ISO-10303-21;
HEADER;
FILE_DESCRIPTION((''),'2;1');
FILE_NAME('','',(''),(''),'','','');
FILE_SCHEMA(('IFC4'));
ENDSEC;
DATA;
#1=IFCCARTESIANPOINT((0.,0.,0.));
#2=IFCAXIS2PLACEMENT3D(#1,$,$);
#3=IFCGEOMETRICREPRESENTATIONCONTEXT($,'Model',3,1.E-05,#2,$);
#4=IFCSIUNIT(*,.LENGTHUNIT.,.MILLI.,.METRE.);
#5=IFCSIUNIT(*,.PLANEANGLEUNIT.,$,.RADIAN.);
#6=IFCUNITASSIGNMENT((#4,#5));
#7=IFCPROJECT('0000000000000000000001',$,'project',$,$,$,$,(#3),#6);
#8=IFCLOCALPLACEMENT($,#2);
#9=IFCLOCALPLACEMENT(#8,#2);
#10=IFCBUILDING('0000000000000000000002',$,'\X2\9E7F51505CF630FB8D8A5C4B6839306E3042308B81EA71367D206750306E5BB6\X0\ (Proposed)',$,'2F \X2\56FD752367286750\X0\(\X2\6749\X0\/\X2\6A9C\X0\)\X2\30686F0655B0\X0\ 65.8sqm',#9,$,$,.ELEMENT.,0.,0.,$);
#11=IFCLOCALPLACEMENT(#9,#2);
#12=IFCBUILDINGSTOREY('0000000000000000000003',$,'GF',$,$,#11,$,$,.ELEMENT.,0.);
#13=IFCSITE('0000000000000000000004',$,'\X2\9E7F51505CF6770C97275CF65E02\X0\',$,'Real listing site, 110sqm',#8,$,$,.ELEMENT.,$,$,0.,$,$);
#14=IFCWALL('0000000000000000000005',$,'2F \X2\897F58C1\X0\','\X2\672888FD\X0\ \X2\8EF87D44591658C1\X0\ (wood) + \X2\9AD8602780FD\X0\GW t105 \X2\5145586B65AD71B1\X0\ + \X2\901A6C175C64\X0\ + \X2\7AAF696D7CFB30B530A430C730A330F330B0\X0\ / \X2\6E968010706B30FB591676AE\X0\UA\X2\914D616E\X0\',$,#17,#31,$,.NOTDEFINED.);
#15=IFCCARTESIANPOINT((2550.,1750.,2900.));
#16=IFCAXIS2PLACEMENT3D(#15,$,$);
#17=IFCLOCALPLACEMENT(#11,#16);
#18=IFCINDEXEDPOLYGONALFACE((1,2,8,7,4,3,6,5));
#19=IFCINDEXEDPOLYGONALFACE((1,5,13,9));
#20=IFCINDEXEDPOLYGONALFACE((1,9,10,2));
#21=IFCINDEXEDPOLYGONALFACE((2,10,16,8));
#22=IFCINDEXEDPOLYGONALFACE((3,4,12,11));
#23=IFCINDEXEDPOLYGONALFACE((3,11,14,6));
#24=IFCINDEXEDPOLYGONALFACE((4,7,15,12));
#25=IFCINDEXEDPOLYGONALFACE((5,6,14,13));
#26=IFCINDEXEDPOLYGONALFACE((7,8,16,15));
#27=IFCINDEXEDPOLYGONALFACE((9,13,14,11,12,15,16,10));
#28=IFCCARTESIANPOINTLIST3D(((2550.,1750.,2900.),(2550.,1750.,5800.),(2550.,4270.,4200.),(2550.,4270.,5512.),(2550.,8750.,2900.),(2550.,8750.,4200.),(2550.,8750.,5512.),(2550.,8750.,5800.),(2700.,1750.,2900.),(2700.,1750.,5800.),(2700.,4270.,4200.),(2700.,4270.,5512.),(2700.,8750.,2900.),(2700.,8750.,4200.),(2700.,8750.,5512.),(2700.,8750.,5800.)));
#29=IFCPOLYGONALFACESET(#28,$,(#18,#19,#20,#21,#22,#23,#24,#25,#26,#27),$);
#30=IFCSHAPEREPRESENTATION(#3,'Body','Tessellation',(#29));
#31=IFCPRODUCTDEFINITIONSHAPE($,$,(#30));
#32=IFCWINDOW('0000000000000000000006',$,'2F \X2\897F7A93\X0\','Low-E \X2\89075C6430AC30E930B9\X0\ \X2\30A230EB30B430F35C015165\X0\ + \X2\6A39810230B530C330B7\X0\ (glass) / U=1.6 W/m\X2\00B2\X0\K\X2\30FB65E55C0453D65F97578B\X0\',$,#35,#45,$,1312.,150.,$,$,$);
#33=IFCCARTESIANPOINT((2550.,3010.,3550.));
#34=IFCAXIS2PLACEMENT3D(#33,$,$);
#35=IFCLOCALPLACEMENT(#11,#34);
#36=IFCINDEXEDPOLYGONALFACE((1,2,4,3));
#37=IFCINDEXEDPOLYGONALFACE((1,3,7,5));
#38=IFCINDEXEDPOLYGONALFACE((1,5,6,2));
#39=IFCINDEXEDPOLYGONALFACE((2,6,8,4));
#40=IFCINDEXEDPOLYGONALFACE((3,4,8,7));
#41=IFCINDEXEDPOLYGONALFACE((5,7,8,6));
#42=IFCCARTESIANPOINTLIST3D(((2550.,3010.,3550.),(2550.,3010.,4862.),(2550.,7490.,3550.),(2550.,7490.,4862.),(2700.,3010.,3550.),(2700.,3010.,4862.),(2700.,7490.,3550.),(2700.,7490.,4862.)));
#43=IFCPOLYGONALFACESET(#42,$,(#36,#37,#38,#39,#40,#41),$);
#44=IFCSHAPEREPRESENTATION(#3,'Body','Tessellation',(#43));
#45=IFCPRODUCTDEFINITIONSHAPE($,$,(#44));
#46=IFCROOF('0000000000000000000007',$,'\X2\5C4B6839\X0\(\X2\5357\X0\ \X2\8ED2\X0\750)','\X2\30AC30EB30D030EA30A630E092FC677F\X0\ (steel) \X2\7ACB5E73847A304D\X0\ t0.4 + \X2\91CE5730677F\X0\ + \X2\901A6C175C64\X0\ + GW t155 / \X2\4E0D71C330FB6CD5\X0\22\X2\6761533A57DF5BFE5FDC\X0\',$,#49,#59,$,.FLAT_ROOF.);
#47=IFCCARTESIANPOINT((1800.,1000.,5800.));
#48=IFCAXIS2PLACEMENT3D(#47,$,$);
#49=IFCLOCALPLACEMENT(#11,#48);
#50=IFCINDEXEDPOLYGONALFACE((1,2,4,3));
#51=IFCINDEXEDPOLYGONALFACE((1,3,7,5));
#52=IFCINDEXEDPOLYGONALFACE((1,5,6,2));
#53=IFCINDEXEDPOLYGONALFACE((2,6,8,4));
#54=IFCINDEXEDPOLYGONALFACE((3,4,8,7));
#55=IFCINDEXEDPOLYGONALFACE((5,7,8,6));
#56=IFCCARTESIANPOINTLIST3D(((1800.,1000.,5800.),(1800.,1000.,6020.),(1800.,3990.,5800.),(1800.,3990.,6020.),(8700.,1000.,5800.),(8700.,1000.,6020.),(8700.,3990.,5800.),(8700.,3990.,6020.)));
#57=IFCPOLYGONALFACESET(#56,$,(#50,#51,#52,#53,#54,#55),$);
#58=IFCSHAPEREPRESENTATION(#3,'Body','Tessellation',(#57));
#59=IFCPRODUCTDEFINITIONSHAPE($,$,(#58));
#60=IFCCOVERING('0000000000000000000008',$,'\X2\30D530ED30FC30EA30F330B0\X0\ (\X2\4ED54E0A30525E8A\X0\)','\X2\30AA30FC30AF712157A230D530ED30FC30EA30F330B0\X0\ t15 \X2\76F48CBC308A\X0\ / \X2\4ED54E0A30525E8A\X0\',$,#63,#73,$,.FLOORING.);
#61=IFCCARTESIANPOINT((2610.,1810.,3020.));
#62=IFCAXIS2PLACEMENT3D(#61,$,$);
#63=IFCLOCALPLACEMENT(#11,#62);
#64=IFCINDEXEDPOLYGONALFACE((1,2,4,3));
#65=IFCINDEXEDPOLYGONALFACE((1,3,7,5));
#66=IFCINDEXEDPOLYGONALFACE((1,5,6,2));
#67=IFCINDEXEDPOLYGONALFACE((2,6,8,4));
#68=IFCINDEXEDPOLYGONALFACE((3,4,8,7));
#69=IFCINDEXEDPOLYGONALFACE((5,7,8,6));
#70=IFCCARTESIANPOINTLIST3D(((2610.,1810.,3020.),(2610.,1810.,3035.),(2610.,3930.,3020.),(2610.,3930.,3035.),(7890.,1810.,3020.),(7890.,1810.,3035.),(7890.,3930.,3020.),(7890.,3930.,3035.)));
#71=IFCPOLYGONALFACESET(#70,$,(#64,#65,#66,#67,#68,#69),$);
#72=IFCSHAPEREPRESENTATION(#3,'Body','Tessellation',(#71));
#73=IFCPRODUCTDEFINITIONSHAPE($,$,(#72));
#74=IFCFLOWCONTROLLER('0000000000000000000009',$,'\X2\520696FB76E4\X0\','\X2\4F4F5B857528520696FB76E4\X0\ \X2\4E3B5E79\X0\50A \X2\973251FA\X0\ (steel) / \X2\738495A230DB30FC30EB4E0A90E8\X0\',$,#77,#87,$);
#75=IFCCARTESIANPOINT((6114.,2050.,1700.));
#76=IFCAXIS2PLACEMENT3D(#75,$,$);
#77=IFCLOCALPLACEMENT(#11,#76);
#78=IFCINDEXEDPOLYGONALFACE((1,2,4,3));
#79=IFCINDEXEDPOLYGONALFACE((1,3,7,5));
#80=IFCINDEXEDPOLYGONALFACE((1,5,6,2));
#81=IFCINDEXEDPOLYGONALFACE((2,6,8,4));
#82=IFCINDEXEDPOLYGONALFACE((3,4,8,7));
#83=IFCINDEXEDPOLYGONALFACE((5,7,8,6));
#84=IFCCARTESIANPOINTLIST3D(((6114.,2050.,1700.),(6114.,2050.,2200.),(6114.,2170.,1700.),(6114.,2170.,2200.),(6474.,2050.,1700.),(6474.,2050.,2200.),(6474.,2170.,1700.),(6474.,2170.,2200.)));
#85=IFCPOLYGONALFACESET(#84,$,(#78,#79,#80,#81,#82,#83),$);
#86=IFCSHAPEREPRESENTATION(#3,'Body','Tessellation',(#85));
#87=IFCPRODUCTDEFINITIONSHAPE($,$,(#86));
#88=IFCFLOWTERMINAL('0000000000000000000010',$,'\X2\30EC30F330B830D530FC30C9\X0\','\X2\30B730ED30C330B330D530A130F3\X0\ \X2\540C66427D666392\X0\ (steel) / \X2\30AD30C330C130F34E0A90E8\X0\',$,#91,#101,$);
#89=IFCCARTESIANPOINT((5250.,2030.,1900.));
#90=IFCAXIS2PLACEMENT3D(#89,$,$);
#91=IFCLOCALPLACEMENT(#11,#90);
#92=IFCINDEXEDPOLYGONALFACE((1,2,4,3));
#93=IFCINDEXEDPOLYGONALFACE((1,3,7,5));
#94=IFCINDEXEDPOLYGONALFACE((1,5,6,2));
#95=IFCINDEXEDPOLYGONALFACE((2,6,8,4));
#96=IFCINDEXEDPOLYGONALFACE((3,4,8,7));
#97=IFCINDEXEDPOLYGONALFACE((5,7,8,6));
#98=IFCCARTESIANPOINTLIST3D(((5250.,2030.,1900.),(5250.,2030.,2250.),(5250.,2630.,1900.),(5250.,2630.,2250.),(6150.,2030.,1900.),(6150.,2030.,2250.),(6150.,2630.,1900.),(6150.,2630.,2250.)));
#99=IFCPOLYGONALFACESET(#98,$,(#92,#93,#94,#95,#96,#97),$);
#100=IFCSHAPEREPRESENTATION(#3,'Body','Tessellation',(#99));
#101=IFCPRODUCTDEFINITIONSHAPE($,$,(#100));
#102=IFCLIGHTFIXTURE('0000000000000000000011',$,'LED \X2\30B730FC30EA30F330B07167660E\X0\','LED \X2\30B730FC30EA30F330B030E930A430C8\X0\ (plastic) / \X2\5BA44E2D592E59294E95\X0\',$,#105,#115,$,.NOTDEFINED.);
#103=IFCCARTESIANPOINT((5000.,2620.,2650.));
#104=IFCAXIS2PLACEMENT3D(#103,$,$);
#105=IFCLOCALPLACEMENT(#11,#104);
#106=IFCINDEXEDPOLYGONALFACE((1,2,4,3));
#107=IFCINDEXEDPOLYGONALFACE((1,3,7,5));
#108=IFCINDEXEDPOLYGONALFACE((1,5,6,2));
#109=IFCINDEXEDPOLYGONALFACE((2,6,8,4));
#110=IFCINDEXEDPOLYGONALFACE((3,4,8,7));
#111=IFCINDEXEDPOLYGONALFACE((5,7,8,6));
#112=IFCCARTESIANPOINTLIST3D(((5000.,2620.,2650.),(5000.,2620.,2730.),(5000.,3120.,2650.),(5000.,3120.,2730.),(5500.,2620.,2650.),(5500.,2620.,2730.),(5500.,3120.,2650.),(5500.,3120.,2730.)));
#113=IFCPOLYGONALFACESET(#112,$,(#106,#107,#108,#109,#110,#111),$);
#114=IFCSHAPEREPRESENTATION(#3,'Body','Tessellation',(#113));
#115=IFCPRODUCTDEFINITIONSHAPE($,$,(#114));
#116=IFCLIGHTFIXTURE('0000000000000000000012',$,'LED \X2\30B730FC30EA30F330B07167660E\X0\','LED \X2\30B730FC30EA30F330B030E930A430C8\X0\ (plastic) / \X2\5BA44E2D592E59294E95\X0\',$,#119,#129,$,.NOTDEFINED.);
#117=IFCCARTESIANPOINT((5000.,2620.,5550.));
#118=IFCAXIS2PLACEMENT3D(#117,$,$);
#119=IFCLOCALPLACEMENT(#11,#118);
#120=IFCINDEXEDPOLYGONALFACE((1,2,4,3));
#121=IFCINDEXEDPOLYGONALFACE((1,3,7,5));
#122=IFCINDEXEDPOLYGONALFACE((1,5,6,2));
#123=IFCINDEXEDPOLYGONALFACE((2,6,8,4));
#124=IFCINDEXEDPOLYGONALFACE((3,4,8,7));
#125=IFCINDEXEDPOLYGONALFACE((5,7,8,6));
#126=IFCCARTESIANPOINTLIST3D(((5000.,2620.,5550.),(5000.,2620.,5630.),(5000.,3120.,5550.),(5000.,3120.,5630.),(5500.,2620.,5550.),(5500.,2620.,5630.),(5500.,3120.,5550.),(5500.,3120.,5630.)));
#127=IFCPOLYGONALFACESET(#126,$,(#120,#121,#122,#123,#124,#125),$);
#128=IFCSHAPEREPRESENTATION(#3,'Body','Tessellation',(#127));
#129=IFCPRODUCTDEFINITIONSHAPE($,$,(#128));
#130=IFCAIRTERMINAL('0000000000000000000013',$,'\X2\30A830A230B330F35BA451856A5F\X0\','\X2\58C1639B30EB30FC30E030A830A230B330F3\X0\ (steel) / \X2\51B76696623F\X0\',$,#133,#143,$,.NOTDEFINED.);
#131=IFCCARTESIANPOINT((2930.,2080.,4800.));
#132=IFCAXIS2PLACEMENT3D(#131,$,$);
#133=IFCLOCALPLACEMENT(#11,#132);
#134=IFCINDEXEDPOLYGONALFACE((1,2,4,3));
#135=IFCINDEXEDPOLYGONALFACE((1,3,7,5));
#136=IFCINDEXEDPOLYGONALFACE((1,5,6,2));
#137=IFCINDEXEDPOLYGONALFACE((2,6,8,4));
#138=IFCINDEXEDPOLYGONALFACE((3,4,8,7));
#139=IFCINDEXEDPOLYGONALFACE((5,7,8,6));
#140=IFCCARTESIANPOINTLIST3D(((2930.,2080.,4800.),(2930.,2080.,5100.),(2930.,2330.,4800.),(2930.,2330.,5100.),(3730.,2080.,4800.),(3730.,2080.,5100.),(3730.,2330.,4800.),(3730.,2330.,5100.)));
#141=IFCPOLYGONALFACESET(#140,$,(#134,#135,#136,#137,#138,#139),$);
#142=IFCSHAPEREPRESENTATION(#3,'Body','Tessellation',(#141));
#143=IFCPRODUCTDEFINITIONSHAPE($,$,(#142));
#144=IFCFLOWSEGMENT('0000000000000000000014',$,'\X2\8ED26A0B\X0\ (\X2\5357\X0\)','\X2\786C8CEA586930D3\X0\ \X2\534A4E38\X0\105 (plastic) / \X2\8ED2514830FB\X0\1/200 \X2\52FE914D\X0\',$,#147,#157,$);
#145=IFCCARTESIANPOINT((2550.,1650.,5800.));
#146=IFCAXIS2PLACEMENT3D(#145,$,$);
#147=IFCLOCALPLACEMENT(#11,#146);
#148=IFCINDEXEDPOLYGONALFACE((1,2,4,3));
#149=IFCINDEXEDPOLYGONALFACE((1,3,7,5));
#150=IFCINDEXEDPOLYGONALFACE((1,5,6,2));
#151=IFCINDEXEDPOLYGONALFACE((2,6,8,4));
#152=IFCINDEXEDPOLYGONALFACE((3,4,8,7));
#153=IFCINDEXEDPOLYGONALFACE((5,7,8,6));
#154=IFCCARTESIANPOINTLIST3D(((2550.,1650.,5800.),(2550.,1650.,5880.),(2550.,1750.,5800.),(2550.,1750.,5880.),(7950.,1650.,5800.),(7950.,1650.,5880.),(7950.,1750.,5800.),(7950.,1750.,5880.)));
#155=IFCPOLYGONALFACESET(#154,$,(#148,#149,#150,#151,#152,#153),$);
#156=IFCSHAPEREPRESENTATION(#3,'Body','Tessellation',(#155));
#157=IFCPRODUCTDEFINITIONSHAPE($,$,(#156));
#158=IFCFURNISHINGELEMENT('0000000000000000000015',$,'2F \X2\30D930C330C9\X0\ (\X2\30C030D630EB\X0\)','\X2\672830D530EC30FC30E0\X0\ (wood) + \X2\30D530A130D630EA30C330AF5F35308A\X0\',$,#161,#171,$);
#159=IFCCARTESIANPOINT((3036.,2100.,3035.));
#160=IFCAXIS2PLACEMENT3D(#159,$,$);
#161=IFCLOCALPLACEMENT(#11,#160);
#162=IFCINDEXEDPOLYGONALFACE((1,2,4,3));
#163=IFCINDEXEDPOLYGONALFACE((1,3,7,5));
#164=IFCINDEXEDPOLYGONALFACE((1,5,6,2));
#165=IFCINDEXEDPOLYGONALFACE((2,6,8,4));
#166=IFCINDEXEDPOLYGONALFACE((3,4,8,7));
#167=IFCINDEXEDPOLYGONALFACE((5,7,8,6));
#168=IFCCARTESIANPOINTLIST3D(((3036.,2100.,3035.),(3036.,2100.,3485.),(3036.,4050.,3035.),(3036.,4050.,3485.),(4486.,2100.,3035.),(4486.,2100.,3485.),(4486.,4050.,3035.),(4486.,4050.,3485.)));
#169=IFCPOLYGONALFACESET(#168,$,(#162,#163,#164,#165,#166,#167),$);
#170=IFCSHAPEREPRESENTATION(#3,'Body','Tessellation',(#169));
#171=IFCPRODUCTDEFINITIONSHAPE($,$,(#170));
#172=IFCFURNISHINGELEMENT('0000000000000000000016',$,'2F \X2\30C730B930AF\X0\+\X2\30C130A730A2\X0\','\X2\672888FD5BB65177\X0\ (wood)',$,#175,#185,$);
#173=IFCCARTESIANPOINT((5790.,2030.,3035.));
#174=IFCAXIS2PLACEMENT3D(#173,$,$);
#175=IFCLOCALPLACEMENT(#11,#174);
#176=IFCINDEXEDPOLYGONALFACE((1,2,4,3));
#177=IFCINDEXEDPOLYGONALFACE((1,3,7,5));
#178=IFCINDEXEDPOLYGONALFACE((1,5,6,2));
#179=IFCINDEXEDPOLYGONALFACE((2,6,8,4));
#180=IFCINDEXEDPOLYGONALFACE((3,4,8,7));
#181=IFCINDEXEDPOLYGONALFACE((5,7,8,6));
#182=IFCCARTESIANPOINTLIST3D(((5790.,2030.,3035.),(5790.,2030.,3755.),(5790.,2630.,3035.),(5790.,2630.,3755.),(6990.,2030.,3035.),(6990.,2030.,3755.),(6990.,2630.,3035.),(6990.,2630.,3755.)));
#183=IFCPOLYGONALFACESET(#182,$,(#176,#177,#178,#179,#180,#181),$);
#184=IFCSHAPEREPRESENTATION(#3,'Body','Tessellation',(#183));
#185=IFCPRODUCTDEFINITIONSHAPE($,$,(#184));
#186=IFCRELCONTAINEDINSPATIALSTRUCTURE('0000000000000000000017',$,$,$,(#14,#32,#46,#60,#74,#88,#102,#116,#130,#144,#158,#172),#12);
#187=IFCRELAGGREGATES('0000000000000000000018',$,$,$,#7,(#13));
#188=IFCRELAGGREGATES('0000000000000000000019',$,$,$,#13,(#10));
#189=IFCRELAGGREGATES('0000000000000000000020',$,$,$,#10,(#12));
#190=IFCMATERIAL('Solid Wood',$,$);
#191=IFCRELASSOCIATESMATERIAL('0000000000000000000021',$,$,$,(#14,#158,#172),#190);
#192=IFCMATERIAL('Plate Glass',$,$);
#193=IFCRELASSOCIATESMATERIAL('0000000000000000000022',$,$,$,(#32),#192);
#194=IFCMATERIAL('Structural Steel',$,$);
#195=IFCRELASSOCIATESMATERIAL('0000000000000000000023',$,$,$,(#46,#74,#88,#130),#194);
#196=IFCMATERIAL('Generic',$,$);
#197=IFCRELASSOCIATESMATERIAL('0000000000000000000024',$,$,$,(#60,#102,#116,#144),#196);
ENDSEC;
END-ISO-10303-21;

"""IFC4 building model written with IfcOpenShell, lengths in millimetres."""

from ifc_helpers import new_model, si_unit, frame, frame_2d, origin, place, context, project, spatial, rectangle, extrude, material, element, fill, save


model = new_model("IFC4")

# Units and contexts
model_context = context("Model", 3, precision=1e-05, world=origin())
ifc_project = project(units=[si_unit("LENGTHUNIT", "METRE", prefix="MILLI"), si_unit("PLANEANGLEUNIT", "RADIAN")], contexts=[model_context])

# Site, building, storey
site_placement = place(None, origin())
site = spatial("IfcSite", under=ifc_project, at=site_placement, Name="鹿児島県霧島市", ObjectType="Real listing site, 110sqm", CompositionType="ELEMENT", RefElevation=0.0)
building_placement = place(site_placement, origin())
building = spatial("IfcBuilding", under=site, at=building_placement, Name="鹿児島・越屋根のある自然素材の家 (Proposed)", ObjectType="2F 国産木材(杉/檜)と漆喰 65.8sqm", CompositionType="ELEMENT", ElevationOfRefHeight=0.0, ElevationOfTerrain=0.0)
storey_placement = place(building_placement, origin())
storey = spatial("IfcBuildingStorey", under=building, at=storey_placement, Name="GF", CompositionType="ELEMENT", Elevation=0.0)

# Shared definitions
ifc_material_1 = material(Name="Solid Wood")

# Wall, opening, window
ifc_material_2 = material(Name="Plate Glass")
wall_1_placement = place(storey_placement, frame((2550.0, 1750.0, 2900.0)))
wall_1 = element("IfcWall", 1, at=wall_1_placement, inside=storey, material=ifc_material_1, Name="2F 西壁", Description="木製 軸組外壁 (wood) + 高性能GW t105 充填断熱 + 通気層 + 窯業系サイディング / 準耐火・外皮UA配慮", PredefinedType="NOTDEFINED", context=model_context, shape_type="SweptSolid", body=[
    extrude(rectangle(XDim=150.0, YDim=7000.0, at=frame_2d((75.0, 3500.0))), frame((2550.0, 1750.0, 2900.0)), (0.0, 0.0, 1.0), 2900.0),
])
opening_1_placement = place(storey_placement, frame((2550.0, 3010.0, 3550.0)))
opening_1 = element("IfcOpeningElement", 2, at=opening_1_placement, cuts=wall_1, PredefinedType="NOTDEFINED", context=model_context, shape_type="SweptSolid", body=[
    extrude(rectangle(XDim=150.0, YDim=4480.0, at=frame_2d((75.0, 2240.0))), frame((2550.0, 3010.0, 3550.0)), (0.0, 0.0, 1.0), 1312.0),
])
window_1_placement = place(storey_placement, frame((2550.0, 3010.0, 3550.0)))
window_1 = element("IfcWindow", 3, at=window_1_placement, inside=storey, material=ifc_material_2, Name="2F 西窓", Description="Low-E 複層ガラス アルゴン封入 + 樹脂サッシ (glass) / U=1.6 W/m²K・日射取得型", OverallHeight=1312.0, OverallWidth=150.0, context=model_context, shape_type="SweptSolid", body=[
    extrude(rectangle(XDim=150.0, YDim=4480.0, at=frame_2d((75.0, 2240.0))), frame((2550.0, 3010.0, 3550.0)), (0.0, 0.0, 1.0), 1312.0),
])
fill(opening_1, window_1)

# Roof
ifc_material_3 = material(Name="Structural Steel")
for number, where, name in (
    (4, (1800.0, 1000.0, 5800.0), "屋根(南 軒750)"),
):
    element("IfcRoof", number, at=place(storey_placement, frame(where)), inside=storey, material=ifc_material_3, Name=name, Description="ガルバリウム鋼板 (steel) 立平葺き t0.4 + 野地板 + 通気層 + GW t155 / 不燃・法22条区域対応", PredefinedType="FLAT_ROOF", context=model_context, shape_type="SweptSolid", body=[
        extrude(rectangle(XDim=6900.0, YDim=2990.0, at=frame_2d((3450.0, 1495.0))), frame((1800.0, 1000.0, 5800.0)), (0.0, 0.0, 1.0), 220.0),
    ])

# Covering
ifc_material_4 = material(Name="Generic")
covering_placement = place(storey_placement, frame((2610.0, 1810.0, 3020.0)))
element("IfcCovering", 5, at=covering_placement, inside=storey, material=ifc_material_4, Name="フローリング (仕上げ床)", Description="オーク無垢フローリング t15 直貼り / 仕上げ床", PredefinedType="FLOORING", context=model_context, shape_type="SweptSolid", body=[
    extrude(rectangle(XDim=5280.0, YDim=2120.0, at=frame_2d((2640.0, 1060.0))), frame((2610.0, 1810.0, 3020.0)), (0.0, 0.0, 1.0), 15.0),
])

# Flow controller
flow_controller_placement = place(storey_placement, frame((6114.0, 2050.0, 1700.0)))
element("IfcFlowController", 6, at=flow_controller_placement, inside=storey, material=ifc_material_3, Name="分電盤", Description="住宅用分電盤 主幹50A 露出 (steel) / 玄関ホール上部", context=model_context, shape_type="SweptSolid", body=[
    extrude(rectangle(XDim=360.0, YDim=120.0, at=frame_2d((180.0, 60.0))), frame((6114.0, 2050.0, 1700.0)), (0.0, 0.0, 1.0), 500.0),
])

# Flow terminal
flow_terminal_placement = place(storey_placement, frame((5250.0, 2030.0, 1900.0)))
element("IfcFlowTerminal", 7, at=flow_terminal_placement, inside=storey, material=ifc_material_3, Name="レンジフード", Description="シロッコファン 同時給排 (steel) / キッチン上部", context=model_context, shape_type="SweptSolid", body=[
    extrude(rectangle(XDim=900.0, YDim=600.0, at=frame_2d((450.0, 300.0))), frame((5250.0, 2030.0, 1900.0)), (0.0, 0.0, 1.0), 350.0),
])

# Light fixtures
light_fixture_1_placement = place(storey_placement, frame((5000.0, 2620.0, 2650.0)))
element("IfcLightFixture", 8, at=light_fixture_1_placement, inside=storey, material=ifc_material_4, Name="LED シーリング照明", Description="LED シーリングライト (plastic) / 室中央天井", PredefinedType="NOTDEFINED", context=model_context, shape_type="SweptSolid", body=[
    extrude(rectangle(XDim=500.0, YDim=500.0, at=frame_2d((250.0, 250.0))), frame((5000.0, 2620.0, 2650.0)), (0.0, 0.0, 1.0), 80.0),
])
light_fixture_2_placement = place(storey_placement, frame((5000.0, 2620.0, 5550.0)))
element("IfcLightFixture", 9, at=light_fixture_2_placement, inside=storey, material=ifc_material_4, Name="LED シーリング照明", Description="LED シーリングライト (plastic) / 室中央天井", PredefinedType="NOTDEFINED", context=model_context, shape_type="SweptSolid", body=[
    extrude(rectangle(XDim=500.0, YDim=500.0, at=frame_2d((250.0, 250.0))), frame((5000.0, 2620.0, 5550.0)), (0.0, 0.0, 1.0), 80.0),
])

# Air terminal
air_terminal_placement = place(storey_placement, frame((2930.0, 2080.0, 4800.0)))
element("IfcAirTerminal", 10, at=air_terminal_placement, inside=storey, material=ifc_material_3, Name="エアコン室内機", Description="壁掛ルームエアコン (steel) / 冷暖房", PredefinedType="NOTDEFINED", context=model_context, shape_type="SweptSolid", body=[
    extrude(rectangle(XDim=800.0, YDim=250.0, at=frame_2d((400.0, 125.0))), frame((2930.0, 2080.0, 4800.0)), (0.0, 0.0, 1.0), 300.0),
])

# Flow segment
flow_segment_placement = place(storey_placement, frame((2550.0, 1650.0, 5800.0)))
element("IfcFlowSegment", 11, at=flow_segment_placement, inside=storey, material=ifc_material_4, Name="軒樋 (南)", Description="硬質塩ビ 半丸105 (plastic) / 軒先・1/200 勾配", context=model_context, shape_type="SweptSolid", body=[
    extrude(rectangle(XDim=5400.0, YDim=100.0, at=frame_2d((2700.0, 50.0))), frame((2550.0, 1650.0, 5800.0)), (0.0, 0.0, 1.0), 80.0),
])

# Furnishing elements
furnishing_1_placement = place(storey_placement, frame((3036.0, 2100.0, 3035.0)))
element("IfcFurnishingElement", 12, at=furnishing_1_placement, inside=storey, material=ifc_material_1, Name="2F ベッド (ダブル)", Description="木フレーム (wood) + ファブリック張り", context=model_context, shape_type="SweptSolid", body=[
    extrude(rectangle(XDim=1450.0, YDim=1950.0, at=frame_2d((725.0, 975.0))), frame((3036.0, 2100.0, 3035.0)), (0.0, 0.0, 1.0), 450.0),
])
furnishing_2_placement = place(storey_placement, frame((5790.0, 2030.0, 3035.0)))
element("IfcFurnishingElement", 13, at=furnishing_2_placement, inside=storey, material=ifc_material_1, Name="2F デスク+チェア", Description="木製家具 (wood)", context=model_context, shape_type="SweptSolid", body=[
    extrude(rectangle(XDim=1200.0, YDim=600.0, at=frame_2d((600.0, 300.0))), frame((5790.0, 2030.0, 3035.0)), (0.0, 0.0, 1.0), 720.0),
])

save(model, "model.ifc")
